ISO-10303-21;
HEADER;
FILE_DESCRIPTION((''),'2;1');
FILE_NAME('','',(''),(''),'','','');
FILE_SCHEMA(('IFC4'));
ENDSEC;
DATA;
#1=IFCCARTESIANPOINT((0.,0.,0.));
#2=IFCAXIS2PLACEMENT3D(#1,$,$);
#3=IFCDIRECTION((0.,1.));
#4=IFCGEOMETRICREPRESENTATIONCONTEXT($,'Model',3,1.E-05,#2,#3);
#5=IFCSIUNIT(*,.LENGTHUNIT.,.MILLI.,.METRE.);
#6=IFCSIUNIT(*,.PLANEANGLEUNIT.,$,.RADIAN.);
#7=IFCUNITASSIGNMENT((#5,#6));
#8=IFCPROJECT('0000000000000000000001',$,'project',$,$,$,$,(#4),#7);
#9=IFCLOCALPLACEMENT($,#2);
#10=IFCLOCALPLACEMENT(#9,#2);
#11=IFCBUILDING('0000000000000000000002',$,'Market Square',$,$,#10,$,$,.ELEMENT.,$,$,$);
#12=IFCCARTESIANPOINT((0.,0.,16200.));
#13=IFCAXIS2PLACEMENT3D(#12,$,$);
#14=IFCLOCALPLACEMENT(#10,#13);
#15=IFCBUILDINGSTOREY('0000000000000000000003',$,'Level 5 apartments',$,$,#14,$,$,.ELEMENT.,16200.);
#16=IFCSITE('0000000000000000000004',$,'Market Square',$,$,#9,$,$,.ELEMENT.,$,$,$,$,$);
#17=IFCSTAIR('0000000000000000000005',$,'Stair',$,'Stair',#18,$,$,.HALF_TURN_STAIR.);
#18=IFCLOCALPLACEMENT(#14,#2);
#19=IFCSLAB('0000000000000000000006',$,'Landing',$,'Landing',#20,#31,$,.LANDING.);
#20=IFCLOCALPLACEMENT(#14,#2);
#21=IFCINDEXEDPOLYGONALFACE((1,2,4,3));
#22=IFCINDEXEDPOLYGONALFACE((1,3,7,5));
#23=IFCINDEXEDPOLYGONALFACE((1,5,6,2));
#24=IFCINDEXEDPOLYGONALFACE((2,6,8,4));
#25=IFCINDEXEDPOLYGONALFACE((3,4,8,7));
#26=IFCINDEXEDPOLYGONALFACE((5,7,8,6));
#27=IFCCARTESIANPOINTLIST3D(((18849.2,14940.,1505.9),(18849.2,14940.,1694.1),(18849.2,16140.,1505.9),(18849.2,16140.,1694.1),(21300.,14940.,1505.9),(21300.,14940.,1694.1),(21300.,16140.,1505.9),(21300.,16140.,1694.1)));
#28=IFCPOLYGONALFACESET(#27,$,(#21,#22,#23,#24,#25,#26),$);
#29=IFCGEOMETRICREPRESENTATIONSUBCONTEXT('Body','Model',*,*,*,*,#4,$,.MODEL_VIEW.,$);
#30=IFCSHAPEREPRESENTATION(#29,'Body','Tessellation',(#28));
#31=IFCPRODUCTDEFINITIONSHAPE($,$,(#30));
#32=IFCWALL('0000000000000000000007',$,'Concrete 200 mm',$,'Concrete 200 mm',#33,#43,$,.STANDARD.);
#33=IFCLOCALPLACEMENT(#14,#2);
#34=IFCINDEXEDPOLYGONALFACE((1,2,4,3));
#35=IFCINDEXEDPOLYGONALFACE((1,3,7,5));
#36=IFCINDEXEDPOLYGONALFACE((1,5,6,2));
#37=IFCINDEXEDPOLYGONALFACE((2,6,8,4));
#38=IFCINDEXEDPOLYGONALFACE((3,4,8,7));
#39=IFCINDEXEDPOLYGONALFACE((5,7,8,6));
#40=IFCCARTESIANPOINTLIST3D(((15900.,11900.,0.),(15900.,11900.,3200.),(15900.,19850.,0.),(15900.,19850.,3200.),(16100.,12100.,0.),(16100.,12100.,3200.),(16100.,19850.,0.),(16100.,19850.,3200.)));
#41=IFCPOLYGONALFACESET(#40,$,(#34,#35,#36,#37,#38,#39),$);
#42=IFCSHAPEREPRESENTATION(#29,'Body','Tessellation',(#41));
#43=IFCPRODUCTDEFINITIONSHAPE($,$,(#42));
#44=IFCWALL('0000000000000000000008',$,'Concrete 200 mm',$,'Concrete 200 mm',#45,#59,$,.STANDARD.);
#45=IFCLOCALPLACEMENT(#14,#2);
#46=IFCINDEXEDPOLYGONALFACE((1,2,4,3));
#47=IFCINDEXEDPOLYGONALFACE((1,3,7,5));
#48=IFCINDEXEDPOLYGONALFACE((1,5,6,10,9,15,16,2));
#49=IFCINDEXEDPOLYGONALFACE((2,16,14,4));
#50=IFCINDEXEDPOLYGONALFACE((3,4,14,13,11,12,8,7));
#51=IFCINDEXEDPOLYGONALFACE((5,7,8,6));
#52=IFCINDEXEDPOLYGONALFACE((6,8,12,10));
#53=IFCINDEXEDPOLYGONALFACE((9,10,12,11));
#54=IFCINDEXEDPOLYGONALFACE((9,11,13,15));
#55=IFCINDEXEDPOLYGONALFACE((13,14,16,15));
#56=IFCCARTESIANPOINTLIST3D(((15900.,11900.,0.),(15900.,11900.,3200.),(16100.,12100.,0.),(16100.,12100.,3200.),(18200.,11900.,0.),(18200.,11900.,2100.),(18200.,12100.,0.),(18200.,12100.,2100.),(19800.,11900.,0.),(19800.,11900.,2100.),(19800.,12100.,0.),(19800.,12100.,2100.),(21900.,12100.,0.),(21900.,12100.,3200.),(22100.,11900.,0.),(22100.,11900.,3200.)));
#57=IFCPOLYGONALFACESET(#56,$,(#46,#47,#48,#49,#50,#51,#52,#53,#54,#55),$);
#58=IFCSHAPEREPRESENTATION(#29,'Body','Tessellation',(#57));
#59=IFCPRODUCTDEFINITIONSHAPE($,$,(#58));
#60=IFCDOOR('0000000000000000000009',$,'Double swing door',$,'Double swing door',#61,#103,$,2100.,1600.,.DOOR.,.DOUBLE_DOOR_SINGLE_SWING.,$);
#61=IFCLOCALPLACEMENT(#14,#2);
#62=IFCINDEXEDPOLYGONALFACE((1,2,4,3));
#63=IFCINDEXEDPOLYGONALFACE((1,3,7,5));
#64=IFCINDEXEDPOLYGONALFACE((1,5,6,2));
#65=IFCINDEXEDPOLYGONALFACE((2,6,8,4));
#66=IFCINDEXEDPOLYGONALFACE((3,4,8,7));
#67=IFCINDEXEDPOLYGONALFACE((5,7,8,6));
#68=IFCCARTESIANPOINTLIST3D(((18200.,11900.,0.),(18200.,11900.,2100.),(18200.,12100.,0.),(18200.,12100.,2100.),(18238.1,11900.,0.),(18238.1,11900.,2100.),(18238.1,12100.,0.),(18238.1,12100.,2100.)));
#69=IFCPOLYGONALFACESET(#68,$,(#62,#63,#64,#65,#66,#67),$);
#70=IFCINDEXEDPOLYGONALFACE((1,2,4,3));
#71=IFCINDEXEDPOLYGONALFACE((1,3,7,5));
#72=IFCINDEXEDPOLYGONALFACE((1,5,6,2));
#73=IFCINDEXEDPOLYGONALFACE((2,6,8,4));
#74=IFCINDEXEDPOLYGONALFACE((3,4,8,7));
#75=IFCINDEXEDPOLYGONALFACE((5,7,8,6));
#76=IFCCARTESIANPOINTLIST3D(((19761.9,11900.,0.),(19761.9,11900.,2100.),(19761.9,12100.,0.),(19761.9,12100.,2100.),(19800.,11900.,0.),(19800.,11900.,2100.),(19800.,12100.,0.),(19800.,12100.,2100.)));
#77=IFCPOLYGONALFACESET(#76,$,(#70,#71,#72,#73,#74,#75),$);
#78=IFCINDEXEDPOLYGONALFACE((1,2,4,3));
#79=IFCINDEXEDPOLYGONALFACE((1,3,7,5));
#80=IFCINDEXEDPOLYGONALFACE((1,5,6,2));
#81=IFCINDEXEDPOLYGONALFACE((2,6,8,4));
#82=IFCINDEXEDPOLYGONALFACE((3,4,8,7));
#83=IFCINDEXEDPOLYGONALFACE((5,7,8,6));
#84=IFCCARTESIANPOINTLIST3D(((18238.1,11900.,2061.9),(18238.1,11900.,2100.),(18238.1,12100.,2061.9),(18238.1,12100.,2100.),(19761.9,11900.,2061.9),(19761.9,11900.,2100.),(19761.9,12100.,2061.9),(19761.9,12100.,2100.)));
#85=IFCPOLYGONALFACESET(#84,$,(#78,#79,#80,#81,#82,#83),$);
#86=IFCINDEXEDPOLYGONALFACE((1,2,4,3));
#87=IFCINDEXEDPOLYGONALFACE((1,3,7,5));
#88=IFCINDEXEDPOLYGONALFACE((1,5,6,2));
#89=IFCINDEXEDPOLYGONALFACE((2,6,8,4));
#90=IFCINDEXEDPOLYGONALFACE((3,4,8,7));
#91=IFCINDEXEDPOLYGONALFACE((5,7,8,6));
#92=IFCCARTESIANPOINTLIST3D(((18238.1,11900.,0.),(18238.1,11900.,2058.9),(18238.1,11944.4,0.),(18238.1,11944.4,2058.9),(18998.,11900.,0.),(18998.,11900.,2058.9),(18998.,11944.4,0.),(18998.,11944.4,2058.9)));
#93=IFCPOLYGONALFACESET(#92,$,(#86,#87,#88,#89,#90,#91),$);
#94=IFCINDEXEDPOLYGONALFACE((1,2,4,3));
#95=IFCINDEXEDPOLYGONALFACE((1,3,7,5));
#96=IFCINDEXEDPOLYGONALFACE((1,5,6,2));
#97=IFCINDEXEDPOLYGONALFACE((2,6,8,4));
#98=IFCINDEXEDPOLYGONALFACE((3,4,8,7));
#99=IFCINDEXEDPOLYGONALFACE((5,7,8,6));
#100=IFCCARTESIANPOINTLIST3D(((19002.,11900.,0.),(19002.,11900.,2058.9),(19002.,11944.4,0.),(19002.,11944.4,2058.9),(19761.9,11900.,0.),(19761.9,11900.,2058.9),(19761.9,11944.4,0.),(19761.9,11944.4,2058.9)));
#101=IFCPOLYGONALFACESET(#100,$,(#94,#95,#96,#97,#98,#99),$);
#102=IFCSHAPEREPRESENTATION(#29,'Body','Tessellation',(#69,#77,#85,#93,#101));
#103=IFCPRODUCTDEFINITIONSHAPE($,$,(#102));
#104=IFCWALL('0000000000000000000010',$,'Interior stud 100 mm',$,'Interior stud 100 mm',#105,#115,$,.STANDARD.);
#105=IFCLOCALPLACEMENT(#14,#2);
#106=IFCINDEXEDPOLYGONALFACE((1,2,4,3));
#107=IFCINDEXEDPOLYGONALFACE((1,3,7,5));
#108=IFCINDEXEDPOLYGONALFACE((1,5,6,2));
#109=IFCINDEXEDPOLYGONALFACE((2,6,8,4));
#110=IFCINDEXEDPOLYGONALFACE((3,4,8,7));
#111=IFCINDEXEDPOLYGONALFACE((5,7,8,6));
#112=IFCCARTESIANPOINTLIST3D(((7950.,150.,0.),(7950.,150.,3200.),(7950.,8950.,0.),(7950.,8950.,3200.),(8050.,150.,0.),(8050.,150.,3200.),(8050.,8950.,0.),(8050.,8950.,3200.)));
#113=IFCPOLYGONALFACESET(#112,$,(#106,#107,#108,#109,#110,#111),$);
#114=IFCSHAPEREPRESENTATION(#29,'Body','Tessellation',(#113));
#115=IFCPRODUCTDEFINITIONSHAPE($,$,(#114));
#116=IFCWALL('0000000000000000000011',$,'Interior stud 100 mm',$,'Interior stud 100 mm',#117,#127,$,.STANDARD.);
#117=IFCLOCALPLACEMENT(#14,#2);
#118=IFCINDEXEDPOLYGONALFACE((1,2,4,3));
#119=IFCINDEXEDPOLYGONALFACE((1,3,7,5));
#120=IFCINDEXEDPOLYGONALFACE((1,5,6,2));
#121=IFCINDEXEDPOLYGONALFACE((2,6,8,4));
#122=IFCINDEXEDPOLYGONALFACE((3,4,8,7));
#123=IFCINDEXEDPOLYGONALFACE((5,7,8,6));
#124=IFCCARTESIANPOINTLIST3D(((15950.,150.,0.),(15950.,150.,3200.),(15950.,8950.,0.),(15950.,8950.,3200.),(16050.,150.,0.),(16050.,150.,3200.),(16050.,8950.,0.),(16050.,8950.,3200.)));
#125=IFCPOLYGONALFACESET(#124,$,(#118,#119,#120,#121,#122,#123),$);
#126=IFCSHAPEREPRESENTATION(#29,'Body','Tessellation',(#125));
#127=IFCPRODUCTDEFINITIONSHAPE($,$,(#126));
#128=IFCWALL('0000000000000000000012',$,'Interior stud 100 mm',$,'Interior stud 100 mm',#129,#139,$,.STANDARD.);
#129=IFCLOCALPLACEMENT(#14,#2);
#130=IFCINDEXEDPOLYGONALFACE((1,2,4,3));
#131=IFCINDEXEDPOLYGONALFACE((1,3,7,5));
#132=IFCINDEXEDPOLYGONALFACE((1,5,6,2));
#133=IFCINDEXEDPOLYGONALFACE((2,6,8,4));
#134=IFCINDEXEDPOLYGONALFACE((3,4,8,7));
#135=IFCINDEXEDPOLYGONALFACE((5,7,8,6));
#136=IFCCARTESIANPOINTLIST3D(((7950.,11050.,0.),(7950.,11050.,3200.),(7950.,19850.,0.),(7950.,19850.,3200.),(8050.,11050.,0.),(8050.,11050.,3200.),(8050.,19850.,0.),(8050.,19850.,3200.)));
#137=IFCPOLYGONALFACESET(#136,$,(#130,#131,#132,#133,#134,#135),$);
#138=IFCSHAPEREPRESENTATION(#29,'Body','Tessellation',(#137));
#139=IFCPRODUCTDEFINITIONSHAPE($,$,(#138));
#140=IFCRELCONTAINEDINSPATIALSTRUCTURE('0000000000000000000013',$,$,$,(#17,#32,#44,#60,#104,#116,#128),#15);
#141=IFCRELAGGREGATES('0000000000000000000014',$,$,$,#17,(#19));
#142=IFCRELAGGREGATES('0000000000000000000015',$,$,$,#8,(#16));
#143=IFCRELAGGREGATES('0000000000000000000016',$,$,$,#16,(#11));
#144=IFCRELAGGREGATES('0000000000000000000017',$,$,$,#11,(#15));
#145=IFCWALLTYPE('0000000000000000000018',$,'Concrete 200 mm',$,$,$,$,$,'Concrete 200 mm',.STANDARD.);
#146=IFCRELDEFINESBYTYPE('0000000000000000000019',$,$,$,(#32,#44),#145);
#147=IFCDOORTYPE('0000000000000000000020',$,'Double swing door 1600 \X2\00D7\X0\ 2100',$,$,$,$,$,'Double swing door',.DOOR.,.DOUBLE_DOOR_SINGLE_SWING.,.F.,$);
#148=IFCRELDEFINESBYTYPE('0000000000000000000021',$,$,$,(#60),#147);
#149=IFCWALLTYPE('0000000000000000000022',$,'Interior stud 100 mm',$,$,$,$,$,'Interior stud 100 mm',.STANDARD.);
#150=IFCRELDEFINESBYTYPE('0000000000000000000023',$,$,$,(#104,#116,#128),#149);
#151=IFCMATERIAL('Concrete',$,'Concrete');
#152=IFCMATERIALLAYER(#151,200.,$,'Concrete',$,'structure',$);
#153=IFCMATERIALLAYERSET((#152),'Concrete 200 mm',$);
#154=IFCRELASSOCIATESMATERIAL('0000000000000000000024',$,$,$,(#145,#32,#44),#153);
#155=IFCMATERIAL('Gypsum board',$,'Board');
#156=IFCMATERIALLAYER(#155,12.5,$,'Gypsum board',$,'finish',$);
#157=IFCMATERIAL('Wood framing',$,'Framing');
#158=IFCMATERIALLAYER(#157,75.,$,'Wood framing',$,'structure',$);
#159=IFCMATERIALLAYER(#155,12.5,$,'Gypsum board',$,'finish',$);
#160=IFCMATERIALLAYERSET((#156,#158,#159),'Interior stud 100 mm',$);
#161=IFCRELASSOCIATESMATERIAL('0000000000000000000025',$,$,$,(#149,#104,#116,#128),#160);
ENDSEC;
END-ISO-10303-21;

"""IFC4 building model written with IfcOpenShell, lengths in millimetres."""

from ifc_helpers import new_model, si_unit, direction, frame, origin, origin_with_axes, place, context, subcontext, project, spatial, polyline, outline, extrude, material, layer, layer_set, layer_usage, type_object, element, fill, aggregate, save


model = new_model("IFC4")

# Units and contexts
model_context = context("Model", 3, precision=1e-05, world=origin(), true_north=direction((0.0, 1.0)))
body_context = subcontext(model_context, "Body", "Model", "MODEL_VIEW")
ifc_project = project(units=[si_unit("LENGTHUNIT", "METRE", prefix="MILLI"), si_unit("PLANEANGLEUNIT", "RADIAN")], contexts=[model_context])

# Site, building, storey
site_placement = place(None, origin())
site = spatial("IfcSite", under=ifc_project, at=site_placement, Name="Market Square", CompositionType="ELEMENT")
building_placement = place(site_placement, origin())
building = spatial("IfcBuilding", under=site, at=building_placement, Name="Market Square", CompositionType="ELEMENT")
storey_placement = place(building_placement, frame((0.0, 0.0, 16200.0)))
storey = spatial("IfcBuildingStorey", under=building, at=storey_placement, Name="Level 5 apartments", CompositionType="ELEMENT", Elevation=16200.0)

# Stair, slab
stair_placement = place(storey_placement, origin_with_axes())
stair = element("IfcStair", 1, at=stair_placement, inside=storey, Name="Stair", ObjectType="Stair", PredefinedType="HALF_TURN_STAIR")
slab_placement = place(storey_placement, origin_with_axes())
slab = element("IfcSlab", 2, at=slab_placement, Name="Landing", ObjectType="Landing", PredefinedType="LANDING", context=body_context, shape_type="SweptSolid", body=[
    extrude(outline(polyline([(21300.0, 14940.0), (21300.0, 16140.0), (18849.2, 16140.0), (18849.2, 14940.0), (21300.0, 14940.0)])), frame((0.0, 0.0, 1505.9)), (0.0, 0.0, 1.0), 188.2),
])

# Wall
ifc_material_1 = material(Name="Concrete", Category="Concrete")
ifc_layer_1 = layer(ifc_material_1, 200.0, Name="Concrete", Category="structure")
ifc_layer_set_1 = layer_set([ifc_layer_1], Name="Concrete 200 mm")
ifc_layer_usage_1 = layer_usage(ifc_layer_set_1, "AXIS2", "NEGATIVE", 100.0)
wall_type_1 = type_object("IfcWallType", Name="Concrete 200 mm", ElementType="Concrete 200 mm", PredefinedType="STANDARD", material=ifc_layer_set_1)
wall_1_placement = place(storey_placement, frame((16000.0, 12000.0, 0.0), z_axis=(0.0, 0.0, 1.0), x_axis=(0.0, 1.0, 0.0)))
element("IfcWall", 3, at=wall_1_placement, inside=storey, type_object=wall_type_1, material=ifc_layer_usage_1, Name="Concrete 200 mm", ObjectType="Concrete 200 mm", PredefinedType="STANDARD", context=body_context, shape_type="SweptSolid", body=[
    extrude(outline(polyline([(100.0, -100.0), (7850.0, -100.0), (7850.0, 100.0), (-100.0, 100.0), (100.0, -100.0)])), origin(), (0.0, 0.0, 1.0), 3200.0),
])

# Wall, opening, door
ifc_layer_usage_2 = layer_usage(ifc_layer_set_1, "AXIS2", "NEGATIVE", 100.0)
wall_2_placement = place(storey_placement, frame((16000.0, 12000.0, 0.0), z_axis=(0.0, 0.0, 1.0), x_axis=(1.0, 0.0, 0.0)))
wall_2 = element("IfcWall", 4, at=wall_2_placement, inside=storey, type_object=wall_type_1, material=ifc_layer_usage_2, Name="Concrete 200 mm", ObjectType="Concrete 200 mm", PredefinedType="STANDARD", context=body_context, shape_type="SweptSolid", body=[
    extrude(outline(polyline([(-100.0, -100.0), (6100.0, -100.0), (5900.0, 100.0), (100.0, 100.0), (-100.0, -100.0)])), origin(), (0.0, 0.0, 1.0), 3200.0),
])
opening_placement = place(wall_2_placement, frame((2200.0, 0.0, 0.0), z_axis=(0.0, 0.0, 1.0), x_axis=(1.0, 0.0, 0.0)))
opening = element("IfcOpeningElement", 5, at=opening_placement, cuts=wall_2, PredefinedType="OPENING", context=body_context, shape_type="SweptSolid", body=[
    extrude(outline(polyline([(0.0, -110.0), (1600.0, -110.0), (1600.0, 110.0), (0.0, 110.0), (0.0, -110.0)])), origin(), (0.0, 0.0, 1.0), 2100.0),
])
door_type = type_object("IfcDoorType", Name="Double swing door 1600 × 2100", ElementType="Double swing door", OperationType="DOUBLE_DOOR_SINGLE_SWING", ParameterTakesPrecedence=False, PredefinedType="DOOR")
door_placement = place(opening_placement, origin_with_axes())
door = element("IfcDoor", 6, at=door_placement, inside=storey, type_object=door_type, Name="Double swing door", ObjectType="Double swing door", OperationType="DOUBLE_DOOR_SINGLE_SWING", OverallHeight=2100.0, OverallWidth=1600.0, PredefinedType="DOOR", context=body_context, shape_type="SweptSolid", body=[
    extrude(outline(polyline([(0.0, -100.0), (38.1, -100.0), (38.1, 100.0), (0.0, 100.0), (0.0, -100.0)])), origin(), (0.0, 0.0, 1.0), 2100.0),
    extrude(outline(polyline([(1561.9, -100.0), (1600.0, -100.0), (1600.0, 100.0), (1561.9, 100.0), (1561.9, -100.0)])), origin(), (0.0, 0.0, 1.0), 2100.0),
    extrude(outline(polyline([(38.1, -100.0), (1561.9, -100.0), (1561.9, 100.0), (38.1, 100.0), (38.1, -100.0)])), frame((0.0, 0.0, 2061.9)), (0.0, 0.0, 1.0), 38.1),
    extrude(outline(polyline([(38.1, -100.0), (798.0, -100.0), (798.0, -55.5), (38.1, -55.5), (38.1, -100.0)])), origin(), (0.0, 0.0, 1.0), 2058.9),
    extrude(outline(polyline([(802.0, -100.0), (1561.9, -100.0), (1561.9, -55.5), (802.0, -55.5), (802.0, -100.0)])), origin(), (0.0, 0.0, 1.0), 2058.9),
])
fill(opening, door)

# Walls
ifc_material_2 = material(Name="Gypsum board", Category="Board")
ifc_layer_2 = layer(ifc_material_2, 12.5, Name="Gypsum board", Category="finish")
ifc_material_3 = material(Name="Wood framing", Category="Framing")
ifc_layer_3 = layer(ifc_material_3, 75.0, Name="Wood framing", Category="structure")
ifc_layer_4 = layer(ifc_material_2, 12.5, Name="Gypsum board", Category="finish")
ifc_layer_set_2 = layer_set([ifc_layer_2, ifc_layer_3, ifc_layer_4], Name="Interior stud 100 mm")
ifc_layer_usage_3 = layer_usage(ifc_layer_set_2, "AXIS2", "NEGATIVE", 50.0)
wall_type_2 = type_object("IfcWallType", Name="Interior stud 100 mm", ElementType="Interior stud 100 mm", PredefinedType="STANDARD", material=ifc_layer_set_2)
wall_3_placement = place(storey_placement, frame((8000.0, 0.0, 0.0), z_axis=(0.0, 0.0, 1.0), x_axis=(0.0, 1.0, 0.0)))
element("IfcWall", 7, at=wall_3_placement, inside=storey, type_object=wall_type_2, material=ifc_layer_usage_3, Name="Interior stud 100 mm", ObjectType="Interior stud 100 mm", PredefinedType="STANDARD", context=body_context, shape_type="SweptSolid", body=[
    extrude(outline(polyline([(150.0, -50.0), (8950.0, -50.0), (8950.0, 50.0), (150.0, 50.0), (150.0, -50.0)])), origin(), (0.0, 0.0, 1.0), 3200.0),
])
ifc_layer_usage_4 = layer_usage(ifc_layer_set_2, "AXIS2", "NEGATIVE", 50.0)
wall_4_placement = place(storey_placement, frame((16000.0, 0.0, 0.0), z_axis=(0.0, 0.0, 1.0), x_axis=(0.0, 1.0, 0.0)))
element("IfcWall", 8, at=wall_4_placement, inside=storey, type_object=wall_type_2, material=ifc_layer_usage_4, Name="Interior stud 100 mm", ObjectType="Interior stud 100 mm", PredefinedType="STANDARD", context=body_context, shape_type="SweptSolid", body=[
    extrude(outline(polyline([(150.0, -50.0), (8950.0, -50.0), (8950.0, 50.0), (150.0, 50.0), (150.0, -50.0)])), origin(), (0.0, 0.0, 1.0), 3200.0),
])
ifc_layer_usage_5 = layer_usage(ifc_layer_set_2, "AXIS2", "NEGATIVE", 50.0)
wall_5_placement = place(storey_placement, frame((8000.0, 11000.0, 0.0), z_axis=(0.0, 0.0, 1.0), x_axis=(0.0, 1.0, 0.0)))
element("IfcWall", 9, at=wall_5_placement, inside=storey, type_object=wall_type_2, material=ifc_layer_usage_5, Name="Interior stud 100 mm", ObjectType="Interior stud 100 mm", PredefinedType="STANDARD", context=body_context, shape_type="SweptSolid", body=[
    extrude(outline(polyline([(50.0, -50.0), (8850.0, -50.0), (8850.0, 50.0), (50.0, 50.0), (50.0, -50.0)])), origin(), (0.0, 0.0, 1.0), 3200.0),
])

aggregate(stair, [slab])

save(model, "model.ifc")
